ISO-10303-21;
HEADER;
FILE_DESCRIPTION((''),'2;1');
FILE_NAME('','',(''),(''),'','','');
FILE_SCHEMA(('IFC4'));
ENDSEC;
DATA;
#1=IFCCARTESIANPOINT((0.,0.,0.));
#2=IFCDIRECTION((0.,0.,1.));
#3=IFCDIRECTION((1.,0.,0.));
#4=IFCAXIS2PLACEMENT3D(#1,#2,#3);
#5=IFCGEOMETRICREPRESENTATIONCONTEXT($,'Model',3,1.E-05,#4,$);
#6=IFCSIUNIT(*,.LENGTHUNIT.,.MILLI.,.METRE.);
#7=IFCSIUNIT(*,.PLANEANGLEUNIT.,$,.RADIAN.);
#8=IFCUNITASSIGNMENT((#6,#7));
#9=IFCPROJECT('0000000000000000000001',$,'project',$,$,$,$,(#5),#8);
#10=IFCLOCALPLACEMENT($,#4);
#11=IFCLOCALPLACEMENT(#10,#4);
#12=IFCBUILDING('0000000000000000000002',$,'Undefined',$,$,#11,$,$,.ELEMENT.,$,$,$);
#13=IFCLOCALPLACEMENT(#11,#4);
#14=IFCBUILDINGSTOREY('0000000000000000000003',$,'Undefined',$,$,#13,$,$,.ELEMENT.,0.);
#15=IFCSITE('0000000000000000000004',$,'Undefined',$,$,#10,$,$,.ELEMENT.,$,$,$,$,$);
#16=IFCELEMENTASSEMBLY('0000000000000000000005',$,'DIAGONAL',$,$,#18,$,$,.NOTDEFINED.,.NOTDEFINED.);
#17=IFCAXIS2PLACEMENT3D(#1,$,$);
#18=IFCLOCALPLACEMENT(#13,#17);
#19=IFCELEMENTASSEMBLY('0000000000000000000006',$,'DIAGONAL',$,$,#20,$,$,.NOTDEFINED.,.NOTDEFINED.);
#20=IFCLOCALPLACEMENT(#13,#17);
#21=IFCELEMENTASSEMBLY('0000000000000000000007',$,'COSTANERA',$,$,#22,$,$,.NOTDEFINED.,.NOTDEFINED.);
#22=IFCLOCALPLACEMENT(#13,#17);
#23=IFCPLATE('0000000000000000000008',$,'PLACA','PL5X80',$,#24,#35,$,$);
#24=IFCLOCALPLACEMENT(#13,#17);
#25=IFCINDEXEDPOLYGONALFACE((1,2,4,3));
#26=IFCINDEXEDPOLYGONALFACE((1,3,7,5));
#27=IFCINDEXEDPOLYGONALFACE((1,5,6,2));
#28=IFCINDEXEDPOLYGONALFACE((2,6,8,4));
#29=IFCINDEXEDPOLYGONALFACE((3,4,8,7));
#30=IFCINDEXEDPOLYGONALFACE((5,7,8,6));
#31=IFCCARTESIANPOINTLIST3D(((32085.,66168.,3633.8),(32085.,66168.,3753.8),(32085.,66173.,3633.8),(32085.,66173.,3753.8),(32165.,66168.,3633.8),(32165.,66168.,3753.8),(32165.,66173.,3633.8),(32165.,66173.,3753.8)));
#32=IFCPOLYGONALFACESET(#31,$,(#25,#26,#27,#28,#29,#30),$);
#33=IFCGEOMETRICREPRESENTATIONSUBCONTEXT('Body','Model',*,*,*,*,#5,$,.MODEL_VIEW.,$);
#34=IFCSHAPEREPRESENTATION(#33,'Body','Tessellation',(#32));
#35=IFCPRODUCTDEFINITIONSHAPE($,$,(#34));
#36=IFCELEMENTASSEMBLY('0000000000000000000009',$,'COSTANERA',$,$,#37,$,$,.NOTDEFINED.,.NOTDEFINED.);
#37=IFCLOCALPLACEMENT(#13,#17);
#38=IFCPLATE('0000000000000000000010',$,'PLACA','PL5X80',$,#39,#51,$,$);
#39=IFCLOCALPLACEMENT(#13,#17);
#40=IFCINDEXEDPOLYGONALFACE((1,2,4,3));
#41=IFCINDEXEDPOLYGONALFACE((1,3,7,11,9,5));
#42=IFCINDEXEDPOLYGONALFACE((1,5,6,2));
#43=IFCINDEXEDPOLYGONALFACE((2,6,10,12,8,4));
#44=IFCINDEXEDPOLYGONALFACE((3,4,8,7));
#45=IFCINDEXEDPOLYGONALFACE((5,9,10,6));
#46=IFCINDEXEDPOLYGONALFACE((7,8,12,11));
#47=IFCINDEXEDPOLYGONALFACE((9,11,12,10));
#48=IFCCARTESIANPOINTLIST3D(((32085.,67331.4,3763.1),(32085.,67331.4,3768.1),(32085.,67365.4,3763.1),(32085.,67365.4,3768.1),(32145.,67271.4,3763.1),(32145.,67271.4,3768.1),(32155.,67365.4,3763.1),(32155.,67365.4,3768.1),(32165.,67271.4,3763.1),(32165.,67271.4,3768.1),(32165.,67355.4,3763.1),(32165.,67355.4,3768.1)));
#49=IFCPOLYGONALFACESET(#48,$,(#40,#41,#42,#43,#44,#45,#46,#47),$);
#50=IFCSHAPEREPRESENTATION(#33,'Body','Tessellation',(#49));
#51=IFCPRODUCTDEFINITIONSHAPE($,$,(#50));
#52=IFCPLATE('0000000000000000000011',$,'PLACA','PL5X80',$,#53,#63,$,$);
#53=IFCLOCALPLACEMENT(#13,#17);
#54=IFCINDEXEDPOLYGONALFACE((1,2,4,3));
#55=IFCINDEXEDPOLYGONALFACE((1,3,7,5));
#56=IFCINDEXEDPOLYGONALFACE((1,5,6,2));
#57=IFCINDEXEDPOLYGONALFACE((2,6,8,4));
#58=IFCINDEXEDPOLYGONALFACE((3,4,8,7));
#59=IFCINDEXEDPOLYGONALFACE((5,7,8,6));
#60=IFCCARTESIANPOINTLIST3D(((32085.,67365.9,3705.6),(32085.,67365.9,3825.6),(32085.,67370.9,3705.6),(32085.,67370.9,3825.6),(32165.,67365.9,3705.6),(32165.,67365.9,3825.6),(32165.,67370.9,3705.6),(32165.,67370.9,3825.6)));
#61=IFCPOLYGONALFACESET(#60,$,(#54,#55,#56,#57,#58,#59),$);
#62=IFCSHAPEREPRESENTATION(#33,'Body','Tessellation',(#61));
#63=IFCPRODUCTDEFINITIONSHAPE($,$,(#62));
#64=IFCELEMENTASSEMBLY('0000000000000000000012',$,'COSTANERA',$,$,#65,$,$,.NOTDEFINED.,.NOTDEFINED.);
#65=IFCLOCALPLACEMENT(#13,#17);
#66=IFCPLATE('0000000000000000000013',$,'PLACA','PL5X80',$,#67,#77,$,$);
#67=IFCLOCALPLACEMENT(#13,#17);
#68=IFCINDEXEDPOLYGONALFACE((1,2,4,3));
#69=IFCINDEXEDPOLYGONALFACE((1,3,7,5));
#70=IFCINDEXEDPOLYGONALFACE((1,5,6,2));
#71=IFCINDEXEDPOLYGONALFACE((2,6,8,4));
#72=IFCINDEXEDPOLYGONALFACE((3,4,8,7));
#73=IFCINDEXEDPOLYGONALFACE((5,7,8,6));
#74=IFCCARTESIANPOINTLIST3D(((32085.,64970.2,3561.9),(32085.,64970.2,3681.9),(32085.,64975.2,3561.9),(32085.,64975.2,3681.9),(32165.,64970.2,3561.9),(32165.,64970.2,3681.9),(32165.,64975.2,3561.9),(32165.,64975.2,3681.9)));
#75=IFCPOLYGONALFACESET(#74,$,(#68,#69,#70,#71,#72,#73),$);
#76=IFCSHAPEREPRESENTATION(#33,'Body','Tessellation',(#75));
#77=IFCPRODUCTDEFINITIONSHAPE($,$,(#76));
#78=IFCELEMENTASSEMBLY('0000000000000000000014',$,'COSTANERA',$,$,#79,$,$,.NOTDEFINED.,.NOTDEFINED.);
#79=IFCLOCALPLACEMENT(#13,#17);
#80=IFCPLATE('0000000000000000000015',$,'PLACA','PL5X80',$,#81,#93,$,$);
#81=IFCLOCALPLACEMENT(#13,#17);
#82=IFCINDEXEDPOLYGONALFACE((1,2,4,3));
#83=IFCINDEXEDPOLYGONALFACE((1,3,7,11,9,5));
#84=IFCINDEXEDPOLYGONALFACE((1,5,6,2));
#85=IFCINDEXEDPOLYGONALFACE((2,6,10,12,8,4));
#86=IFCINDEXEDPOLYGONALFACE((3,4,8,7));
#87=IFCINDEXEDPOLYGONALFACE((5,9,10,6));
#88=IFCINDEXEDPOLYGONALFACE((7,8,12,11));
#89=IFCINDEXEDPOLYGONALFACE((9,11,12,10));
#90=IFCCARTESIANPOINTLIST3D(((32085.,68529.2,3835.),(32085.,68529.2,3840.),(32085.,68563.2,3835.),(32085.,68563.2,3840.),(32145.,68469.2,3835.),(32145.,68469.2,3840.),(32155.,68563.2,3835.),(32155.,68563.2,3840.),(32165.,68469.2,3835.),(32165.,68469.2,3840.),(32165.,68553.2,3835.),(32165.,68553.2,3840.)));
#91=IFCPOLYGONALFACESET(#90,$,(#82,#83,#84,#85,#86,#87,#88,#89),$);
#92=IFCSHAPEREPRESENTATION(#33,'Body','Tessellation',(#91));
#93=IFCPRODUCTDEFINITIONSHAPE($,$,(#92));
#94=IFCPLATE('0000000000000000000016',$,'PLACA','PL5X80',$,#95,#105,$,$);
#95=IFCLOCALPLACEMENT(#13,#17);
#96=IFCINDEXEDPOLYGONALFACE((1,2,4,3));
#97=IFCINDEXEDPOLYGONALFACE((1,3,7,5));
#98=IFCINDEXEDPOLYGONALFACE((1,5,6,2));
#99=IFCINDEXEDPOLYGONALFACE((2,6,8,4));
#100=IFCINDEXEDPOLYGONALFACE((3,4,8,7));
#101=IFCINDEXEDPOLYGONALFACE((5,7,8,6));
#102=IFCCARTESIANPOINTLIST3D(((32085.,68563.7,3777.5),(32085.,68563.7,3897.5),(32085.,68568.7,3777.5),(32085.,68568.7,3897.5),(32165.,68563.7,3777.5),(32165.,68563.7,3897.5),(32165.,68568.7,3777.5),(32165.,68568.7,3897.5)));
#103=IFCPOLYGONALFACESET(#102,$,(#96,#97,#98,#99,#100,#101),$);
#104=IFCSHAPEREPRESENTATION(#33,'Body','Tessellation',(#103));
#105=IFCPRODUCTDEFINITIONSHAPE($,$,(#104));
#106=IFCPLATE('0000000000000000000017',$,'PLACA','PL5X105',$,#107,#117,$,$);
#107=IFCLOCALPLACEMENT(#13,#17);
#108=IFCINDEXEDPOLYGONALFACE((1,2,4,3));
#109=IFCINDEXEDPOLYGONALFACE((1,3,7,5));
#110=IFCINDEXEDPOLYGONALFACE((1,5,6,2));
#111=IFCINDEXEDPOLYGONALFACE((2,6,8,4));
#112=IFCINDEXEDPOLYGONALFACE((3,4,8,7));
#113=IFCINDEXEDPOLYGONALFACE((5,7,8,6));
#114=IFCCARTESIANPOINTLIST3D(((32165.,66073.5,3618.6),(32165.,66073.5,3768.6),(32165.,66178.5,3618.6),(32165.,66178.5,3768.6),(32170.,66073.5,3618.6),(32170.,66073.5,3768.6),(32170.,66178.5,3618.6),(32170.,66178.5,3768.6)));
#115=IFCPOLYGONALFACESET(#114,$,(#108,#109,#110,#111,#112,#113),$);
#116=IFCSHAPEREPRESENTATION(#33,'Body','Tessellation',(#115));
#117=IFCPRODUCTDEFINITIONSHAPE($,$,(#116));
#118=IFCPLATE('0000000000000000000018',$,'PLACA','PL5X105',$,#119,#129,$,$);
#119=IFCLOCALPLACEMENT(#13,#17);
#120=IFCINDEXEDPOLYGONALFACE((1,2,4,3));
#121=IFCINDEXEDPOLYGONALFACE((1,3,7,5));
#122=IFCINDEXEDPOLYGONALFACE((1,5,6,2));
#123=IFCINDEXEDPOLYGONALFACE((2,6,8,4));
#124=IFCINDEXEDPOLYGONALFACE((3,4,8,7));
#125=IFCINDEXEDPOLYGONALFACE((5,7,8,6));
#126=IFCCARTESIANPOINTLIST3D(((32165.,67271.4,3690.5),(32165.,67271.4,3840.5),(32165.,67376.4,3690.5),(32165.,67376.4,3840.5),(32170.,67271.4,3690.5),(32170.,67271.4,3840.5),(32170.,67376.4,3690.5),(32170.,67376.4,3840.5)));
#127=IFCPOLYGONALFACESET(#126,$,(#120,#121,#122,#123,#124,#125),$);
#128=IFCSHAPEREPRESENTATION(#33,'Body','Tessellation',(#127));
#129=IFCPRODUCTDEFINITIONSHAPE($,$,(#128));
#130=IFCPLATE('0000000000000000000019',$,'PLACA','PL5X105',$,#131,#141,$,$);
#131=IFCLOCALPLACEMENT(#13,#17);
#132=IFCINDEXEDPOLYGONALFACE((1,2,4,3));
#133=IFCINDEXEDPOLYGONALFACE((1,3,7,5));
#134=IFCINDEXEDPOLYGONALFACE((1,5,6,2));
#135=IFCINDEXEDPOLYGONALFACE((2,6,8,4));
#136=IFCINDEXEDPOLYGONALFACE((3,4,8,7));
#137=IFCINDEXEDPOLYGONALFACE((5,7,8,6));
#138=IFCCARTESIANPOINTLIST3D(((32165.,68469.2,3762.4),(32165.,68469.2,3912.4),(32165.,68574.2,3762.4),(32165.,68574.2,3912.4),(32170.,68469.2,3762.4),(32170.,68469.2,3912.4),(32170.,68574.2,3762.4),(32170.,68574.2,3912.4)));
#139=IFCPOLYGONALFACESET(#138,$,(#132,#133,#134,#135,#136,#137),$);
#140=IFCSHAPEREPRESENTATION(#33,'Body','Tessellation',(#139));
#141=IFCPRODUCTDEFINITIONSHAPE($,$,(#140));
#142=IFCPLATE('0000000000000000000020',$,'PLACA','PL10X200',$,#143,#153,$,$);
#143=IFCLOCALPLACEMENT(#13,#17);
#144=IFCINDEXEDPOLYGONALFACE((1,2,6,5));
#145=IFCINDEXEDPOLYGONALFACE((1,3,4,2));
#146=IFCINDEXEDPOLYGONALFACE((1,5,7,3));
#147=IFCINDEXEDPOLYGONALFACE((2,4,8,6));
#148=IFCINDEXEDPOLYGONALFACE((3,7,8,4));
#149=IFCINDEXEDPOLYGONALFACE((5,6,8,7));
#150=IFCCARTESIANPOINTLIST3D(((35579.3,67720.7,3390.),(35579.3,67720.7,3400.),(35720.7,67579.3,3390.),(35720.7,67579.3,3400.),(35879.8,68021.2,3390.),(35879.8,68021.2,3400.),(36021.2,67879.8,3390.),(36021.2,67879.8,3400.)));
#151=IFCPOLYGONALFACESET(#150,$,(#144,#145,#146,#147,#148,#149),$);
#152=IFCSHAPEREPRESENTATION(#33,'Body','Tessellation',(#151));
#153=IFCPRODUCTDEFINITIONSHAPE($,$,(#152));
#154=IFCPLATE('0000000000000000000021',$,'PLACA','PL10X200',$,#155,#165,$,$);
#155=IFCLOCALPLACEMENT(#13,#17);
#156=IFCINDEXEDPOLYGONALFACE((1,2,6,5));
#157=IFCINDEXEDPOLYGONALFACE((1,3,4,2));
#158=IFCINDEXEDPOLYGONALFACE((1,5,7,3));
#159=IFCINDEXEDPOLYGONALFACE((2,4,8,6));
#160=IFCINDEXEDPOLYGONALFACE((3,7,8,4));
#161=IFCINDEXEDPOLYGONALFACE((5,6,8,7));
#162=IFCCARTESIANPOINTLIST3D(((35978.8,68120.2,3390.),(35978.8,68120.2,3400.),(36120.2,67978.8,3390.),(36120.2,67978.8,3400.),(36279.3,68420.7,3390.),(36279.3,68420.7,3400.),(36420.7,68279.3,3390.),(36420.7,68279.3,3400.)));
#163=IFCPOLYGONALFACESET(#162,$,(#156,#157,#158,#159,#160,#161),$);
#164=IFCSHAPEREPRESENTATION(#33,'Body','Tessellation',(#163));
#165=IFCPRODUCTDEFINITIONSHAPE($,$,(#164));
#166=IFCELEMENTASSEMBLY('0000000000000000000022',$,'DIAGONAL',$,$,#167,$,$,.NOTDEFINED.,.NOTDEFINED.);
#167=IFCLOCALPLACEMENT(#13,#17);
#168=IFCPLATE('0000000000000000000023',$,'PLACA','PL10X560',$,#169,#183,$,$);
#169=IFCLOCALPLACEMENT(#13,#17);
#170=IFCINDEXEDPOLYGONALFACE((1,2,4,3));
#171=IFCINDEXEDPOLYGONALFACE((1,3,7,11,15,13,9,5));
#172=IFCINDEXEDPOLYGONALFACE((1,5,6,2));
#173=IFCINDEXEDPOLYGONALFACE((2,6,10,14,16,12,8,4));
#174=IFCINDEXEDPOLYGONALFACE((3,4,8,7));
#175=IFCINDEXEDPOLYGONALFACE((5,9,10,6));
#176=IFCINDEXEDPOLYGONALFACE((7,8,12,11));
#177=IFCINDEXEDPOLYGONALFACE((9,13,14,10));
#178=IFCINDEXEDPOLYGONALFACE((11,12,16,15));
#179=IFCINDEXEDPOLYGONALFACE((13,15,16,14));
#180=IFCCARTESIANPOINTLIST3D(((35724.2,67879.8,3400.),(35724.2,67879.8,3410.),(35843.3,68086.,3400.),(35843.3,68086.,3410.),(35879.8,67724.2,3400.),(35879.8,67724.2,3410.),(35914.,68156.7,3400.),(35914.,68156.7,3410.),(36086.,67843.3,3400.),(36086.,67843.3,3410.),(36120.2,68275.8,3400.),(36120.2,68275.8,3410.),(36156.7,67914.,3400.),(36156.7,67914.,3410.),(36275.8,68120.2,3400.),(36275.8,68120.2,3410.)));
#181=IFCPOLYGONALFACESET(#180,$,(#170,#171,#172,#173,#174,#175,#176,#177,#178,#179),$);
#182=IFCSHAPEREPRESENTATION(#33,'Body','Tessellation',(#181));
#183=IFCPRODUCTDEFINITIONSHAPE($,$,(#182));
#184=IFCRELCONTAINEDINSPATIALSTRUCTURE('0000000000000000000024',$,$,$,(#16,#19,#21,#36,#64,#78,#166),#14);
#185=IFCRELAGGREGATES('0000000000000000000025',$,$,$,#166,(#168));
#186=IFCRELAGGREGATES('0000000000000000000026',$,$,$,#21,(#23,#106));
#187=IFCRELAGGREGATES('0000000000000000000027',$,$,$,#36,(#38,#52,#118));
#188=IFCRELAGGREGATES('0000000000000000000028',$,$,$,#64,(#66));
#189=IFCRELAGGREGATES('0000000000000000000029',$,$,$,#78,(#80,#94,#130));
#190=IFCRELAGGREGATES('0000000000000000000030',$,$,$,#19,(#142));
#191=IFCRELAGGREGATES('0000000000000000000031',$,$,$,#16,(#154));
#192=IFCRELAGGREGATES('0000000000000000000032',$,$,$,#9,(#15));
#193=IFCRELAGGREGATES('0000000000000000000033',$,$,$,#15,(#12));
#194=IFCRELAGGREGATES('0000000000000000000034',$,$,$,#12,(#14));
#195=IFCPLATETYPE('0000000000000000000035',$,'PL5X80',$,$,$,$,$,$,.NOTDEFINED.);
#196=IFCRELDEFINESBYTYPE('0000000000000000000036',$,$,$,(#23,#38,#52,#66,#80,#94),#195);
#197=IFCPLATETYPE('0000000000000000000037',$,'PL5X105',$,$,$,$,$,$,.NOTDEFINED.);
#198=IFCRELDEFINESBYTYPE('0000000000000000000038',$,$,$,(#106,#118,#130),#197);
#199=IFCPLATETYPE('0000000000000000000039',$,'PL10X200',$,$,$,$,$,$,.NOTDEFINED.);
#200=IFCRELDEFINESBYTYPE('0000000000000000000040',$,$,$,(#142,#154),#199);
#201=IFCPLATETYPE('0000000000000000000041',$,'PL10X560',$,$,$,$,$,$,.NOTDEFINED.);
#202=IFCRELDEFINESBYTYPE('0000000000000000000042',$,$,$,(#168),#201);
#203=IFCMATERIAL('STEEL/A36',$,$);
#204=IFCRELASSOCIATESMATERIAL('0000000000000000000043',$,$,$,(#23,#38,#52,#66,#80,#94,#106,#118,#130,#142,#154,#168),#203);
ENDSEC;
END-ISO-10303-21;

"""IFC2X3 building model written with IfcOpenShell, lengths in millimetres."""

from ifc_helpers import new_model, si_unit, frame, origin_with_axes, place, context, subcontext, project, spatial, polyline, outline, extrude, material, type_object, element, aggregate, save


model = new_model("IFC2X3")

# Units and contexts
model_context = context("Model", 3, precision=1e-05, world=origin_with_axes())
body_context = subcontext(model_context, "Body", "Model", "MODEL_VIEW")
ifc_project = project(units=[si_unit("LENGTHUNIT", "METRE", prefix="MILLI"), si_unit("PLANEANGLEUNIT", "RADIAN")], contexts=[model_context])

# Site, building, storey
site_placement = place(None, origin_with_axes())
site = spatial("IfcSite", under=ifc_project, at=site_placement, Name="Undefined", CompositionType="ELEMENT")
building_placement = place(site_placement, origin_with_axes())
building = spatial("IfcBuilding", under=site, at=building_placement, Name="Undefined", CompositionType="ELEMENT")
storey_placement = place(building_placement, origin_with_axes())
storey = spatial("IfcBuildingStorey", under=building, at=storey_placement, Name="Undefined", CompositionType="ELEMENT", Elevation=0.0)

# Element assembly
assembly_1_placement = place(storey_placement, origin_with_axes())
assembly_1 = element("IfcElementAssembly", 1, at=assembly_1_placement, inside=storey, Name="DIAGONAL", AssemblyPlace="NOTDEFINED", PredefinedType="NOTDEFINED")
ifc_material_1 = material(Name="STEEL/A36")

# Element assembly
assembly_2_placement = place(storey_placement, origin_with_axes())
assembly_2 = element("IfcElementAssembly", 2, at=assembly_2_placement, inside=storey, Name="DIAGONAL", AssemblyPlace="NOTDEFINED", PredefinedType="NOTDEFINED")

# Element assemblies, plates
assembly_3_placement = place(storey_placement, origin_with_axes())
assembly_3 = element("IfcElementAssembly", 3, at=assembly_3_placement, inside=storey, Name="COSTANERA", AssemblyPlace="NOTDEFINED", PredefinedType="NOTDEFINED")
plate_type_1 = type_object("IfcPlateType", Name="PL5X80", PredefinedType="NOTDEFINED")
plate_1_placement = place(assembly_3_placement, frame((32085.0, 66170.5, 3753.8), z_axis=(0.0, 1.0, 0.0), x_axis=(1.0, 0.0, 0.0)))
plate_1 = element("IfcPlate", 4, at=plate_1_placement, type_object=plate_type_1, material=ifc_material_1, Name="PLACA", Description="PL5X80", context=body_context, shape_type="SweptSolid", body=[
    extrude(outline(polyline([(0.0, 0.0), (80.0, 0.0), (80.0, 120.0), (0.0, 120.0), (0.0, 0.0)])), frame((0.0, 0.0, -2.5), z_axis=(0.0, 0.0, 1.0), x_axis=(1.0, 0.0, 0.0)), (0.0, 0.0, 1.0), 5.0),
])
assembly_4_placement = place(storey_placement, origin_with_axes())
assembly_4 = element("IfcElementAssembly", 5, at=assembly_4_placement, inside=storey, Name="COSTANERA", AssemblyPlace="NOTDEFINED", PredefinedType="NOTDEFINED")
plate_2_placement = place(assembly_4_placement, frame((32085.0, 67365.4, 3765.6), z_axis=(0.0, 0.0, -1.0), x_axis=(1.0, 0.0, 0.0)))
plate_2 = element("IfcPlate", 6, at=plate_2_placement, type_object=plate_type_1, material=ifc_material_1, Name="PLACA", Description="PL5X80", context=body_context, shape_type="SweptSolid", body=[
    extrude(outline(polyline([(0.0, 0.0), (70.0, 0.0), (80.0, 10.0), (80.0, 94.0), (60.0, 94.0), (0.0, 34.0), (0.0, 0.0)])), frame((0.0, 0.0, -2.5), z_axis=(0.0, 0.0, 1.0), x_axis=(1.0, 0.0, 0.0)), (0.0, 0.0, 1.0), 5.0),
])
plate_3_placement = place(assembly_4_placement, frame((32085.0, 67368.4, 3825.6), z_axis=(0.0, 1.0, 0.0), x_axis=(1.0, 0.0, 0.0)))
plate_3 = element("IfcPlate", 7, at=plate_3_placement, type_object=plate_type_1, material=ifc_material_1, Name="PLACA", Description="PL5X80", context=body_context, shape_type="SweptSolid", body=[
    extrude(outline(polyline([(0.0, 0.0), (80.0, 0.0), (80.0, 120.0), (0.0, 120.0), (0.0, 0.0)])), frame((0.0, 0.0, -2.5), z_axis=(0.0, 0.0, 1.0), x_axis=(1.0, 0.0, 0.0)), (0.0, 0.0, 1.0), 5.0),
])

# Element assembly, plate
assembly_5_placement = place(storey_placement, origin_with_axes())
assembly_5 = element("IfcElementAssembly", 8, at=assembly_5_placement, inside=storey, Name="COSTANERA", AssemblyPlace="NOTDEFINED", PredefinedType="NOTDEFINED")
plate_4_placement = place(assembly_5_placement, frame((32085.0, 64972.7, 3681.9), z_axis=(0.0, 1.0, 0.0), x_axis=(1.0, 0.0, 0.0)))
plate_4 = element("IfcPlate", 9, at=plate_4_placement, type_object=plate_type_1, material=ifc_material_1, Name="PLACA", Description="PL5X80", context=body_context, shape_type="SweptSolid", body=[
    extrude(outline(polyline([(0.0, 0.0), (80.0, 0.0), (80.0, 120.0), (0.0, 120.0), (0.0, 0.0)])), frame((0.0, 0.0, -2.5), z_axis=(0.0, 0.0, 1.0), x_axis=(1.0, 0.0, 0.0)), (0.0, 0.0, 1.0), 5.0),
])

# Element assembly, plates
assembly_6_placement = place(storey_placement, origin_with_axes())
assembly_6 = element("IfcElementAssembly", 10, at=assembly_6_placement, inside=storey, Name="COSTANERA", AssemblyPlace="NOTDEFINED", PredefinedType="NOTDEFINED")
plate_5_placement = place(assembly_6_placement, frame((32085.0, 68563.2, 3837.5), z_axis=(0.0, 0.0, -1.0), x_axis=(1.0, 0.0, 0.0)))
plate_5 = element("IfcPlate", 11, at=plate_5_placement, type_object=plate_type_1, material=ifc_material_1, Name="PLACA", Description="PL5X80", context=body_context, shape_type="SweptSolid", body=[
    extrude(outline(polyline([(0.0, 0.0), (70.0, 0.0), (80.0, 10.0), (80.0, 94.0), (60.0, 94.0), (0.0, 34.0), (0.0, 0.0)])), frame((0.0, 0.0, -2.5), z_axis=(0.0, 0.0, 1.0), x_axis=(1.0, 0.0, 0.0)), (0.0, 0.0, 1.0), 5.0),
])
plate_6_placement = place(assembly_6_placement, frame((32085.0, 68566.2, 3897.5), z_axis=(0.0, 1.0, 0.0), x_axis=(1.0, 0.0, 0.0)))
plate_6 = element("IfcPlate", 12, at=plate_6_placement, type_object=plate_type_1, material=ifc_material_1, Name="PLACA", Description="PL5X80", context=body_context, shape_type="SweptSolid", body=[
    extrude(outline(polyline([(0.0, 0.0), (80.0, 0.0), (80.0, 120.0), (0.0, 120.0), (0.0, 0.0)])), frame((0.0, 0.0, -2.5), z_axis=(0.0, 0.0, 1.0), x_axis=(1.0, 0.0, 0.0)), (0.0, 0.0, 1.0), 5.0),
])

# Plates
plate_type_2 = type_object("IfcPlateType", Name="PL5X105", PredefinedType="NOTDEFINED")
plate_7_placement = place(assembly_3_placement, frame((32167.5, 66073.5, 3618.6), z_axis=(1.0, 0.0, 0.0), x_axis=(0.0, 1.0, 0.0)))
plate_7 = element("IfcPlate", 13, at=plate_7_placement, type_object=plate_type_2, material=ifc_material_1, Name="PLACA", Description="PL5X105", context=body_context, shape_type="SweptSolid", body=[
    extrude(outline(polyline([(0.0, 0.0), (105.0, 0.0), (105.0, 150.0), (0.0, 150.0), (0.0, 0.0)])), frame((0.0, 0.0, -2.5), z_axis=(0.0, 0.0, 1.0), x_axis=(1.0, 0.0, 0.0)), (0.0, 0.0, 1.0), 5.0),
])
plate_8_placement = place(assembly_4_placement, frame((32167.5, 67271.4, 3690.5), z_axis=(1.0, 0.0, 0.0), x_axis=(0.0, 1.0, 0.0)))
plate_8 = element("IfcPlate", 14, at=plate_8_placement, type_object=plate_type_2, material=ifc_material_1, Name="PLACA", Description="PL5X105", context=body_context, shape_type="SweptSolid", body=[
    extrude(outline(polyline([(0.0, 0.0), (105.0, 0.0), (105.0, 150.0), (0.0, 150.0), (0.0, 0.0)])), frame((0.0, 0.0, -2.5), z_axis=(0.0, 0.0, 1.0), x_axis=(1.0, 0.0, 0.0)), (0.0, 0.0, 1.0), 5.0),
])
plate_9_placement = place(assembly_6_placement, frame((32167.5, 68469.2, 3762.4), z_axis=(1.0, 0.0, 0.0), x_axis=(0.0, 1.0, 0.0)))
plate_9 = element("IfcPlate", 15, at=plate_9_placement, type_object=plate_type_2, material=ifc_material_1, Name="PLACA", Description="PL5X105", context=body_context, shape_type="SweptSolid", body=[
    extrude(outline(polyline([(0.0, 0.0), (105.0, 0.0), (105.0, 150.0), (0.0, 150.0), (0.0, 0.0)])), frame((0.0, 0.0, -2.5), z_axis=(0.0, 0.0, 1.0), x_axis=(1.0, 0.0, 0.0)), (0.0, 0.0, 1.0), 5.0),
])
plate_type_3 = type_object("IfcPlateType", Name="PL10X200", PredefinedType="NOTDEFINED")
plate_10_placement = place(assembly_2_placement, frame((35950.5, 67950.5, 3395.0), z_axis=(0.0, 0.0, 1.0), x_axis=(-0.707107, -0.707107, 0.0)))
plate_10 = element("IfcPlate", 16, at=plate_10_placement, type_object=plate_type_3, material=ifc_material_1, Name="PLACA", Description="PL10X200", context=body_context, shape_type="SweptSolid", body=[
    extrude(outline(polyline([(0.0, -100.0), (0.0, 100.0), (425.0, 100.0), (425.0, -100.0), (0.0, -100.0)])), frame((0.0, 0.0, -5.0), z_axis=(0.0, 0.0, 1.0), x_axis=(1.0, 0.0, 0.0)), (0.0, 0.0, 1.0), 10.0),
])
plate_11_placement = place(assembly_1_placement, frame((36049.5, 68049.5, 3395.0), z_axis=(0.0, 0.0, 1.0), x_axis=(0.707107, 0.707107, 0.0)))
plate_11 = element("IfcPlate", 17, at=plate_11_placement, type_object=plate_type_3, material=ifc_material_1, Name="PLACA", Description="PL10X200", context=body_context, shape_type="SweptSolid", body=[
    extrude(outline(polyline([(0.0, -100.0), (0.0, 100.0), (425.0, 100.0), (425.0, -100.0), (0.0, -100.0)])), frame((0.0, 0.0, -5.0), z_axis=(0.0, 0.0, 1.0), x_axis=(1.0, 0.0, 0.0)), (0.0, 0.0, 1.0), 10.0),
])

# Element assembly, plate
assembly_7_placement = place(storey_placement, origin_with_axes())
assembly_7 = element("IfcElementAssembly", 18, at=assembly_7_placement, inside=storey, Name="DIAGONAL", AssemblyPlace="NOTDEFINED", PredefinedType="NOTDEFINED")
plate_type_4 = type_object("IfcPlateType", Name="PL10X560", PredefinedType="NOTDEFINED")
plate_12_placement = place(assembly_7_placement, frame((35843.3, 68086.0, 3405.0), z_axis=(0.0, 0.0, -1.0), x_axis=(0.707107, 0.707107, 0.0)))
plate_12 = element("IfcPlate", 19, at=plate_12_placement, type_object=plate_type_4, material=ifc_material_1, Name="PLACA", Description="PL10X560", context=body_context, shape_type="SweptSolid", body=[
    extrude(outline(polyline([(0.0, 0.0), (100.0, 0.0), (330.0, 61.6), (330.0, 281.6), (100.0, 343.3), (0.0, 343.3), (-230.0, 281.6), (-230.0, 61.6), (0.0, 0.0)])), frame((0.0, 0.0, -5.0), z_axis=(0.0, 0.0, 1.0), x_axis=(1.0, 0.0, 0.0)), (0.0, 0.0, 1.0), 10.0),
])
aggregate(assembly_7, [plate_12])

aggregate(assembly_3, [plate_1, plate_7])
aggregate(assembly_4, [plate_2, plate_3, plate_8])
aggregate(assembly_5, [plate_4])
aggregate(assembly_6, [plate_5, plate_6, plate_9])
aggregate(assembly_2, [plate_10])
aggregate(assembly_1, [plate_11])

save(model, "model.ifc")
